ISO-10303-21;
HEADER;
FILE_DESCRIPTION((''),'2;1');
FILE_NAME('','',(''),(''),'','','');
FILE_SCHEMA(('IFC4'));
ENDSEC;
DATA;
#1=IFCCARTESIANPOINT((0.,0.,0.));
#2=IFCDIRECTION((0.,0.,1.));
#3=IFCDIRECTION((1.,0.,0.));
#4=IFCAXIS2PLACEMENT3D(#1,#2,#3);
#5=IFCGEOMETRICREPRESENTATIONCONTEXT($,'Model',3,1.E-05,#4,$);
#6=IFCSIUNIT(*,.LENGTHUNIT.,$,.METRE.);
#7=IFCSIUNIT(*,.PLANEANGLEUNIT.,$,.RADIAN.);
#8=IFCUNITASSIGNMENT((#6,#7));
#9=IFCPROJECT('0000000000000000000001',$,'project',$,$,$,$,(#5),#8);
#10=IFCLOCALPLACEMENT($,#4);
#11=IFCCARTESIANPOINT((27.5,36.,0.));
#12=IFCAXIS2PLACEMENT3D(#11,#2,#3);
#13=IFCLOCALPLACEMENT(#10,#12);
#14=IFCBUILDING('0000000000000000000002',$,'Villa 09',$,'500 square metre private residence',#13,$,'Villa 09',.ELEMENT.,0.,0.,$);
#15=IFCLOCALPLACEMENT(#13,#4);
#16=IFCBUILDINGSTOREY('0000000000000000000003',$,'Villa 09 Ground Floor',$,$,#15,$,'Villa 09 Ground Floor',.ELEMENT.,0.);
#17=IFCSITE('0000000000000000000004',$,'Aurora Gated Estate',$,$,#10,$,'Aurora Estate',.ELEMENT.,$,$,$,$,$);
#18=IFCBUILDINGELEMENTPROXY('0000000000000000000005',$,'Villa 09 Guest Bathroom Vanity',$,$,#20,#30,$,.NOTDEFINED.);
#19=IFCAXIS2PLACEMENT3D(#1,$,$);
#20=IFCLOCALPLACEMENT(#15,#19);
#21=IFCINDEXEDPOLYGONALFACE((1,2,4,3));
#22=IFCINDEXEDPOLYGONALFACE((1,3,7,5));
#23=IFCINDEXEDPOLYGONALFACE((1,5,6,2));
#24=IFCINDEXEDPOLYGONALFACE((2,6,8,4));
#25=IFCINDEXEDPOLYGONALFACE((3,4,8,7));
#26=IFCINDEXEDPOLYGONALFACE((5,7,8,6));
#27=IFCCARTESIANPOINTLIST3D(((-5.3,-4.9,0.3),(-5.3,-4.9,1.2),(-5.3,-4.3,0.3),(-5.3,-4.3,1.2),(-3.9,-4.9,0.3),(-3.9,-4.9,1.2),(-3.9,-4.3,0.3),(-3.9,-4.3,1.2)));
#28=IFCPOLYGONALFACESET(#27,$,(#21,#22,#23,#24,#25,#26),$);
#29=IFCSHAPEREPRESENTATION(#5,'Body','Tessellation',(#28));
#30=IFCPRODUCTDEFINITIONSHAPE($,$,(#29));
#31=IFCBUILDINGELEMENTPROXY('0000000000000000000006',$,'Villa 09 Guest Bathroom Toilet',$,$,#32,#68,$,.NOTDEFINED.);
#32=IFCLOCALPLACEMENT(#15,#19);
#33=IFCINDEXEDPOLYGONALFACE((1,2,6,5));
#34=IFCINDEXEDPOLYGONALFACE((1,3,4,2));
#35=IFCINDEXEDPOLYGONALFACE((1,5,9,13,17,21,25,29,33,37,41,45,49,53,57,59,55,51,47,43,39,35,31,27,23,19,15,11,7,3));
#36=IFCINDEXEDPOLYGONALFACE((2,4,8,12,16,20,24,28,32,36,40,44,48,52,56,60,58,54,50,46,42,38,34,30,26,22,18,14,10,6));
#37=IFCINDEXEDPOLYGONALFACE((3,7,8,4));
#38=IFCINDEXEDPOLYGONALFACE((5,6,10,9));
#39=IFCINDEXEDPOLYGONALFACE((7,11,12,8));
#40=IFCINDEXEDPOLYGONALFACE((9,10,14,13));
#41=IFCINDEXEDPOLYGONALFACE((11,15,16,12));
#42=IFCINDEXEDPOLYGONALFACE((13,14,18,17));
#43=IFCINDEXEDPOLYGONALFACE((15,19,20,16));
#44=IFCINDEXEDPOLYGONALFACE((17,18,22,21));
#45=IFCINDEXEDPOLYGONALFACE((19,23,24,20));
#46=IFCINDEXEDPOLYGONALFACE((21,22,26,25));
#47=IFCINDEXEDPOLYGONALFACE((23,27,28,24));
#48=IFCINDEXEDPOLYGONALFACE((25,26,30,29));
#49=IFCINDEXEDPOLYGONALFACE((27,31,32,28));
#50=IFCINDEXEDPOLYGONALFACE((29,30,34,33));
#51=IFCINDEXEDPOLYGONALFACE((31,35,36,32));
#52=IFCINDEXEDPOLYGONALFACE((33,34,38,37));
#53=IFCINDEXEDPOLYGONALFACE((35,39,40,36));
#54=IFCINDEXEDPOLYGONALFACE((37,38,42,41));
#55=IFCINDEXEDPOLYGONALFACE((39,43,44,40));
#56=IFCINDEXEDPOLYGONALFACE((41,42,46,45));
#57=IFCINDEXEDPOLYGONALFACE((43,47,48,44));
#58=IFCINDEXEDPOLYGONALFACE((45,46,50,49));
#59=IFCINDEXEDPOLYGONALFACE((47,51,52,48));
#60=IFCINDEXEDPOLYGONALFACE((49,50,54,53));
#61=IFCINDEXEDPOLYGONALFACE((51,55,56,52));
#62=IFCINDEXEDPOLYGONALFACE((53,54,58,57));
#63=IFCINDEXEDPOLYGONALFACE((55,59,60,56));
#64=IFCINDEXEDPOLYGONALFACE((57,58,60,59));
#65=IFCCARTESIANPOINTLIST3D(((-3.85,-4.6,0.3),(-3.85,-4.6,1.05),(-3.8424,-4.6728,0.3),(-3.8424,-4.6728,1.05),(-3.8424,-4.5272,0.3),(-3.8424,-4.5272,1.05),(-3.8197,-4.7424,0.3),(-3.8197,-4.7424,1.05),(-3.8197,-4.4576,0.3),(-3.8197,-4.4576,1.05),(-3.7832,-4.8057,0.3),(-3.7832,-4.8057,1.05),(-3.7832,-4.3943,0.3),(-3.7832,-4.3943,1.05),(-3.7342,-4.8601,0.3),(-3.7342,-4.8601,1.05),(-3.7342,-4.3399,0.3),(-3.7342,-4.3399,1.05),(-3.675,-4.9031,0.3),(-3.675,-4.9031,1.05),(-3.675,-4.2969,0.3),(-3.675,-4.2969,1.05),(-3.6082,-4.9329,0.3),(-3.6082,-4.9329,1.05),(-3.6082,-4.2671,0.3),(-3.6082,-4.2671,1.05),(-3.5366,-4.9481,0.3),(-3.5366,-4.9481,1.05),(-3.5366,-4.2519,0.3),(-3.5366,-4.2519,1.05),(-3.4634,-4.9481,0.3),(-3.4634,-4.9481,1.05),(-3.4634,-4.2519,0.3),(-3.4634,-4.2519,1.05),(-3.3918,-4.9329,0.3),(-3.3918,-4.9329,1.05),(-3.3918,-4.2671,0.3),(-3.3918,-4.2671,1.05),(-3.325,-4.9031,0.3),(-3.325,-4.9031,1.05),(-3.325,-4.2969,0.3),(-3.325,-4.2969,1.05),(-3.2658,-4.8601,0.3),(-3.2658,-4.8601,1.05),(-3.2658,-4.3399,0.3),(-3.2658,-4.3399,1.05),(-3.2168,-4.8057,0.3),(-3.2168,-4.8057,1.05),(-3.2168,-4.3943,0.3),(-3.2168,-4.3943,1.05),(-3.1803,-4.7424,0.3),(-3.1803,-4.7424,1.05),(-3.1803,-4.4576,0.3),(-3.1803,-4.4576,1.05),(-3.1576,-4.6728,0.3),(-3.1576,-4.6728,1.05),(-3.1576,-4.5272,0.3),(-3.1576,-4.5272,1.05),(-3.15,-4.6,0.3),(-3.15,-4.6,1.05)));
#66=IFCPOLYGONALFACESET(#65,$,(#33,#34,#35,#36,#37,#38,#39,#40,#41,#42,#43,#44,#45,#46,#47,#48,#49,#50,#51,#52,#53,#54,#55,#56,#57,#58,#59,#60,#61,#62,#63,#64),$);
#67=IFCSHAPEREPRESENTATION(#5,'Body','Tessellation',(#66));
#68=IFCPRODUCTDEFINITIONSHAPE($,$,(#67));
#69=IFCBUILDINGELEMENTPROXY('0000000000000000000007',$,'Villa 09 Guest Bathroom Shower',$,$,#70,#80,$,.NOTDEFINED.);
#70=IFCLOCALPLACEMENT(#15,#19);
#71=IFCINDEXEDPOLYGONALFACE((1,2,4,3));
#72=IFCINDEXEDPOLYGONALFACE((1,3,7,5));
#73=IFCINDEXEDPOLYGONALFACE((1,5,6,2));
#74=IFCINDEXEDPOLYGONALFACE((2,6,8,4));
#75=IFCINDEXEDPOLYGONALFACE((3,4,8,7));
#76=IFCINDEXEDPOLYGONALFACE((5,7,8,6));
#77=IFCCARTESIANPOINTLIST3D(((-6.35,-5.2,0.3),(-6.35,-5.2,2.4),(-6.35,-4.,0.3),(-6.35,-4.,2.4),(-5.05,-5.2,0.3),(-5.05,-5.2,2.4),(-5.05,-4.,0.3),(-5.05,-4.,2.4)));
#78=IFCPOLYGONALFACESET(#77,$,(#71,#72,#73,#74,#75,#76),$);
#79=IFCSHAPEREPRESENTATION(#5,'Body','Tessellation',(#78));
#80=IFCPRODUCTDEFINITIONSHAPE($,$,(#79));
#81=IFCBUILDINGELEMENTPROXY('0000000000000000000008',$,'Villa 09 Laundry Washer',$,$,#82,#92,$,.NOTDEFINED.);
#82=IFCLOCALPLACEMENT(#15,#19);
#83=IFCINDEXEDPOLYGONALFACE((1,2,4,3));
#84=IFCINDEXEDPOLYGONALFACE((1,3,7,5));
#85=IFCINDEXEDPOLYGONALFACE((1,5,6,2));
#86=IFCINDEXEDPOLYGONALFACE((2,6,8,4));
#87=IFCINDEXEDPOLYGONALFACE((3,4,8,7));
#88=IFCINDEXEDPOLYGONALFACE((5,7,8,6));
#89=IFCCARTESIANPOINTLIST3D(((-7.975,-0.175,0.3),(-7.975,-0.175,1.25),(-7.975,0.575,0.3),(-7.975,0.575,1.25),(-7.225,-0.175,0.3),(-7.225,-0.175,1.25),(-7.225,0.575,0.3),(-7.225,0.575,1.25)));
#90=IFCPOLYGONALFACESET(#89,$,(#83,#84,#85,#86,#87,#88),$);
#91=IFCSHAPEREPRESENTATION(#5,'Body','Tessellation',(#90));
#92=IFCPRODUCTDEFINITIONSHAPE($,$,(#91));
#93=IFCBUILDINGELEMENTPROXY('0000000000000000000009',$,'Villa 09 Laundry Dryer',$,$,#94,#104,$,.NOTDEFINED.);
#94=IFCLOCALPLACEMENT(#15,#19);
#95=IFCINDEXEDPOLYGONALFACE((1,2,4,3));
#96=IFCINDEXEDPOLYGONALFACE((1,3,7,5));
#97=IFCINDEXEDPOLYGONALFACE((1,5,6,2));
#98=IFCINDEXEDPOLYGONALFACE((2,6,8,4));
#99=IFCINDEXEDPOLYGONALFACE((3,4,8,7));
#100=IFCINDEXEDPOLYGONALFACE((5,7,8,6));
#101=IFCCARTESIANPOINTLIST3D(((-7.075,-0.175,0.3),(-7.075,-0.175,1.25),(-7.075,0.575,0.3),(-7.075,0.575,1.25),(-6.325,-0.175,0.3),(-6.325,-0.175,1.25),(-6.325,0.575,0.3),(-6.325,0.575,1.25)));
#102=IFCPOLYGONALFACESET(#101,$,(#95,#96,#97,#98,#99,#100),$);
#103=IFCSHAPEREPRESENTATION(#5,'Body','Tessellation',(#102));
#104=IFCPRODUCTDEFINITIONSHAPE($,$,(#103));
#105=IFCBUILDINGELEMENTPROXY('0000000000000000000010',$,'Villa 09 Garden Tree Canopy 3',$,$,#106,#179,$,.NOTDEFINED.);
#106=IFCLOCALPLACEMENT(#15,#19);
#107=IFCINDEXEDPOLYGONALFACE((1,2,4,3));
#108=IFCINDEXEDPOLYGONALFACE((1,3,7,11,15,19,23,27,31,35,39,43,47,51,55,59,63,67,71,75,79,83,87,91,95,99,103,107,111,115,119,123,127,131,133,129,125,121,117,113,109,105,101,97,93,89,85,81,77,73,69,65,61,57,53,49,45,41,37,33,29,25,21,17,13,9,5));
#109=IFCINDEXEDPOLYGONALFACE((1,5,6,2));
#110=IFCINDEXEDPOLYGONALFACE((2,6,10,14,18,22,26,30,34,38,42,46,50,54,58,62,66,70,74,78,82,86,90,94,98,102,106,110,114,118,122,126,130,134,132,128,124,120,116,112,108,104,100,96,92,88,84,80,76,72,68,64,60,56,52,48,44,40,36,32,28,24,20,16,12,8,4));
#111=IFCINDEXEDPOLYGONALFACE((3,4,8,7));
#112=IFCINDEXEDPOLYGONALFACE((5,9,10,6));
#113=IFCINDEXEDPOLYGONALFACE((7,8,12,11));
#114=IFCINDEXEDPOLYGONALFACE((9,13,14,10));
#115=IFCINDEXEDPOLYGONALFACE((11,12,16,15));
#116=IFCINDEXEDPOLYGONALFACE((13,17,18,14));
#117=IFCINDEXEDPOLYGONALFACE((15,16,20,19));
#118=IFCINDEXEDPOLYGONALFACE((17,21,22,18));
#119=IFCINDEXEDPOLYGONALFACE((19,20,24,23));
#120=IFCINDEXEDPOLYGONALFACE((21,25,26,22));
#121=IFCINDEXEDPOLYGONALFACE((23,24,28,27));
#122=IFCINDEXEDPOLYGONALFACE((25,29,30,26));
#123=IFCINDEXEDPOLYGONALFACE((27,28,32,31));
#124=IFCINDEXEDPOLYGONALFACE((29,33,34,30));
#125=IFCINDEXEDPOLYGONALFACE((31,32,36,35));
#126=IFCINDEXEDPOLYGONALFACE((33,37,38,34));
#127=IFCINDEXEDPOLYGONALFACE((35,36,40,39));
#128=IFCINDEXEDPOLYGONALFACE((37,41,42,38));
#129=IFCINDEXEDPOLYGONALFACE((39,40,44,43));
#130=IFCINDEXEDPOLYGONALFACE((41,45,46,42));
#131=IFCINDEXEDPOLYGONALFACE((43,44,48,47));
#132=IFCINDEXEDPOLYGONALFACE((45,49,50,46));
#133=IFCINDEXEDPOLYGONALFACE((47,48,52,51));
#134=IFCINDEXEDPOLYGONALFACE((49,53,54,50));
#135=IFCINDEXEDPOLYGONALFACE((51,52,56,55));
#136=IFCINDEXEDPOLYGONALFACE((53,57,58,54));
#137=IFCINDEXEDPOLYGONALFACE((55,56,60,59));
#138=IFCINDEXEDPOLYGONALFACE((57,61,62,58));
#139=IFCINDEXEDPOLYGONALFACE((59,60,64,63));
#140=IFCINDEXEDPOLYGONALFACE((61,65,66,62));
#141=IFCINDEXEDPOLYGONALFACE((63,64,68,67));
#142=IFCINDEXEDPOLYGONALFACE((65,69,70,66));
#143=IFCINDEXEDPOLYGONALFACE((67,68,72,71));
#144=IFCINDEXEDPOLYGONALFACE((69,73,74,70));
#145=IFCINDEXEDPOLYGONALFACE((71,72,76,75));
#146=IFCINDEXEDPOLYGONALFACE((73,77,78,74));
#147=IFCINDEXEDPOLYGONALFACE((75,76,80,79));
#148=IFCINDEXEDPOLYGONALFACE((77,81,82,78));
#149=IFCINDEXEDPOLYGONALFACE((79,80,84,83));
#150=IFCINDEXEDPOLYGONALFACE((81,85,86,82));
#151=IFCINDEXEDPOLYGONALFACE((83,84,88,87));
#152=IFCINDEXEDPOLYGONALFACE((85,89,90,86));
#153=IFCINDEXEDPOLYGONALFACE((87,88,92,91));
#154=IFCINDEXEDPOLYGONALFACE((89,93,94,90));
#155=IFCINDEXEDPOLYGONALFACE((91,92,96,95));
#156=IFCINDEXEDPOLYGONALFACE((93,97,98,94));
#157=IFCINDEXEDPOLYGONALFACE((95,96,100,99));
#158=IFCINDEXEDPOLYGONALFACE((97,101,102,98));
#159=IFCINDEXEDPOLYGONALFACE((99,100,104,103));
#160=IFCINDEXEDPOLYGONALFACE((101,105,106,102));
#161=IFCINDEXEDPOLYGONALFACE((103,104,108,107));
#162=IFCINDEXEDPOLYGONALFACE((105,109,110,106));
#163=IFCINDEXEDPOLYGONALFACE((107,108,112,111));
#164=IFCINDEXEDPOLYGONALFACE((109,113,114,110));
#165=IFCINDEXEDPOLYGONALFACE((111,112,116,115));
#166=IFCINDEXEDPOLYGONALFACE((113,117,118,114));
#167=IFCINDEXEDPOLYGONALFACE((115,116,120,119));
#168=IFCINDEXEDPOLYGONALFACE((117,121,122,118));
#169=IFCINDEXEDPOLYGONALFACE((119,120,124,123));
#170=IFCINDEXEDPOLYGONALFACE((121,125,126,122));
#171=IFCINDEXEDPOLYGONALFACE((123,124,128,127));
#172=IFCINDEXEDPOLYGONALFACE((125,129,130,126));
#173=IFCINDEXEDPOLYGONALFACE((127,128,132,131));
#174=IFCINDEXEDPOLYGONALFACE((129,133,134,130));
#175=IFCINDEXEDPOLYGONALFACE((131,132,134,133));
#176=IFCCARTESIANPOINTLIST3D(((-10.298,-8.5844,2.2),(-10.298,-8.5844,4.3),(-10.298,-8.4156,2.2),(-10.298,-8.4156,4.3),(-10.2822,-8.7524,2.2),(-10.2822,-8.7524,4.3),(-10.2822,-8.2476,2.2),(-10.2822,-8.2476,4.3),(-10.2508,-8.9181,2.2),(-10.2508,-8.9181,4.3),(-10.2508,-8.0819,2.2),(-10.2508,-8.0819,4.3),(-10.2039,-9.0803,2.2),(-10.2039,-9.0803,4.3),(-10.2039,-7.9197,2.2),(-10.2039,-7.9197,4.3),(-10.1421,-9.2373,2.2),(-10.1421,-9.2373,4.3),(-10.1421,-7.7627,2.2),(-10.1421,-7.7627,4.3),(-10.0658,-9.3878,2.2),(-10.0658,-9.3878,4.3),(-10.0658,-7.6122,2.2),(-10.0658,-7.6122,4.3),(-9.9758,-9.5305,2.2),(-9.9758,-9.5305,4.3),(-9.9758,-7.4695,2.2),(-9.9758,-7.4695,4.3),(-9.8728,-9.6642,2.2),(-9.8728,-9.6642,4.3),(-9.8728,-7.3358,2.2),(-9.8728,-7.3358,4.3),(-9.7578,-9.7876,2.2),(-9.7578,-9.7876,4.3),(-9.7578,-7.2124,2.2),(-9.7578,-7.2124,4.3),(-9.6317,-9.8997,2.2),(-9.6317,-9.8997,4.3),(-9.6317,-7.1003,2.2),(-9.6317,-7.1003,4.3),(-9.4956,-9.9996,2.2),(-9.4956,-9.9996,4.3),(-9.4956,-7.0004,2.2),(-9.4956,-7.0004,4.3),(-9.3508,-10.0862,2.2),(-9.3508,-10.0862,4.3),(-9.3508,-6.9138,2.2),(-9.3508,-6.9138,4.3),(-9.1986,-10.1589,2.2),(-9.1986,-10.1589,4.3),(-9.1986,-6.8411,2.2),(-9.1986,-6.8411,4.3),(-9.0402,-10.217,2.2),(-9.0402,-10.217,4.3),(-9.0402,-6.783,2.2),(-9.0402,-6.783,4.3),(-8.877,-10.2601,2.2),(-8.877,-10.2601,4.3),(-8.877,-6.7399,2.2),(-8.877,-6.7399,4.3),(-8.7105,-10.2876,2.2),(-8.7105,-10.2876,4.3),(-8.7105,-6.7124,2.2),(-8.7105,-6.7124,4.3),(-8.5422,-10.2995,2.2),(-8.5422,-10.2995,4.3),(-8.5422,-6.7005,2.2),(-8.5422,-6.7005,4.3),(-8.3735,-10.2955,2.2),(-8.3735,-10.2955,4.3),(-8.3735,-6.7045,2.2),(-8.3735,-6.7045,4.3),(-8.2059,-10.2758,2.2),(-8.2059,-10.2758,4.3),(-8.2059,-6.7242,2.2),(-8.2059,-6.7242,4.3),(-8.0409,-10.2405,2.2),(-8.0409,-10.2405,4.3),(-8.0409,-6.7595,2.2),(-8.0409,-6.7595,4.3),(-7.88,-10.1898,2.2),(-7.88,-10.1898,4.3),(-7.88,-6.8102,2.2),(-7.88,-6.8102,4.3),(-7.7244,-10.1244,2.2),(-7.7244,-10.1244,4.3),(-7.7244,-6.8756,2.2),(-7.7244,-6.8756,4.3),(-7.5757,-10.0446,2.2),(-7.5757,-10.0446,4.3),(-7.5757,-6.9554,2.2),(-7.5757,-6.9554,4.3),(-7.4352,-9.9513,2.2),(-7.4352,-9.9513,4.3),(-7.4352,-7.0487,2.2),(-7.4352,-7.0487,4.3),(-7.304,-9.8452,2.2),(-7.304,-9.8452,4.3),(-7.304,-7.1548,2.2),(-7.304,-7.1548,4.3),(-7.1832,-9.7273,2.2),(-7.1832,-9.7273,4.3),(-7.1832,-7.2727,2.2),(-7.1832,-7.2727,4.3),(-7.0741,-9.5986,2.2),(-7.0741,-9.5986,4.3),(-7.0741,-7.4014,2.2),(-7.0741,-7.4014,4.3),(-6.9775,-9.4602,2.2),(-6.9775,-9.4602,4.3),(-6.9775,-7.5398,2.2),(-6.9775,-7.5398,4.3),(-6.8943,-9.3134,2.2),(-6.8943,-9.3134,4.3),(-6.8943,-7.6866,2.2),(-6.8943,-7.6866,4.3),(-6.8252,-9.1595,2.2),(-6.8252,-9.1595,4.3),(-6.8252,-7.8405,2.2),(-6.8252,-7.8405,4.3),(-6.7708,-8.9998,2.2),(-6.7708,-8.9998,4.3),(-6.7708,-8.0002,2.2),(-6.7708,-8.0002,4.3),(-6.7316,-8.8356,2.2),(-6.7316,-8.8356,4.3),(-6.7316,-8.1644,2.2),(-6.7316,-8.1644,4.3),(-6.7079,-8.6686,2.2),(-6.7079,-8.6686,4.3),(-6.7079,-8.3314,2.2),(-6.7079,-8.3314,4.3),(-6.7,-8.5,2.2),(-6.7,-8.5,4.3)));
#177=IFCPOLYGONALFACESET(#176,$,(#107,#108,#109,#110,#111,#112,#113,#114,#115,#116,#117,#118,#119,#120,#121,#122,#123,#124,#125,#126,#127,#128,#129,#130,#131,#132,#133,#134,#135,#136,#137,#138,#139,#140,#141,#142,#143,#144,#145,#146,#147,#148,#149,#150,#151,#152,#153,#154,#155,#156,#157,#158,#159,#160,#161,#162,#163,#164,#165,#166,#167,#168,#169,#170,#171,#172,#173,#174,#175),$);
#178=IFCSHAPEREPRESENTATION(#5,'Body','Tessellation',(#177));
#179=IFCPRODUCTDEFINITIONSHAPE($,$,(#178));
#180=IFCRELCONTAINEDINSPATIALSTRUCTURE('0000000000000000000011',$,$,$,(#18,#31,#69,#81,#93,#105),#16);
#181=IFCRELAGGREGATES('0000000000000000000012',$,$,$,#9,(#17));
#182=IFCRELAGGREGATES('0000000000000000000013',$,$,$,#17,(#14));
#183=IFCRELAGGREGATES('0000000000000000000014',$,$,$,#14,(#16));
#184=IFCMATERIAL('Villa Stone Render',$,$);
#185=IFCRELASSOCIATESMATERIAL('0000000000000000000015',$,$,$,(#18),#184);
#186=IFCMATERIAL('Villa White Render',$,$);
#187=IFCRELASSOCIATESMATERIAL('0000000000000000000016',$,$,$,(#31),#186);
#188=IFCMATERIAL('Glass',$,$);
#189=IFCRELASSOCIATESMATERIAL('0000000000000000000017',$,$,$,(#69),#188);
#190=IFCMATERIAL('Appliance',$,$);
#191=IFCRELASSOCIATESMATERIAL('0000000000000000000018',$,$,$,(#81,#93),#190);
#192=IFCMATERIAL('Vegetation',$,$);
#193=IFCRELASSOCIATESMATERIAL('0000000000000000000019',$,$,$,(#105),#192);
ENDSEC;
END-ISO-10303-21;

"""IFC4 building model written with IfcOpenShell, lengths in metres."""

from ifc_helpers import new_model, si_unit, frame, origin_with_axes, origin_2d_with_axis, place, context, project, spatial, rectangle, circle, extrude, material, element, save


model = new_model("IFC4")

# Units and contexts
model_context = context("Model", 3, precision=1e-05, world=origin_with_axes())
ifc_project = project(units=[si_unit("LENGTHUNIT", "METRE"), si_unit("PLANEANGLEUNIT", "RADIAN")], contexts=[model_context])

# Site, building, storey
site_placement = place(None, origin_with_axes())
site = spatial("IfcSite", under=ifc_project, at=site_placement, Name="Aurora Gated Estate", LongName="Aurora Estate", CompositionType="ELEMENT")
building_placement = place(site_placement, frame((27.5, 36.0, 0.0), z_axis=(0.0, 0.0, 1.0), x_axis=(1.0, 0.0, 0.0)))
building = spatial("IfcBuilding", under=site, at=building_placement, Name="Villa 09", ObjectType="500 square metre private residence", LongName="Villa 09", CompositionType="ELEMENT", ElevationOfRefHeight=0.0, ElevationOfTerrain=0.0)
storey_placement = place(building_placement, origin_with_axes())
storey = spatial("IfcBuildingStorey", under=building, at=storey_placement, Name="Villa 09 Ground Floor", LongName="Villa 09 Ground Floor", CompositionType="ELEMENT", Elevation=0.0)

# Shared definitions
ifc_material_1 = material(Name="Villa Stone Render")

# Building element proxies
ifc_material_2 = material(Name="Glass")
proxy_1_placement = place(storey_placement, frame((-4.6, -4.6, 0.3), z_axis=(0.0, 0.0, 1.0), x_axis=(1.0, 0.0, 0.0)))
element("IfcBuildingElementProxy", 1, at=proxy_1_placement, inside=storey, material=ifc_material_1, Name="Villa 09 Guest Bathroom Vanity", PredefinedType="NOTDEFINED", context=model_context, shape_type="SweptSolid", body=[
    extrude(rectangle(XDim=1.4, YDim=0.6, at=origin_2d_with_axis()), origin_with_axes(), (0.0, 0.0, 1.0), 0.9),
])
ifc_material_3 = material(Name="Villa White Render")
proxy_2_placement = place(storey_placement, frame((-3.5, -4.6, 0.3), z_axis=(0.0, 0.0, 1.0), x_axis=(1.0, 0.0, 0.0)))
element("IfcBuildingElementProxy", 2, at=proxy_2_placement, inside=storey, material=ifc_material_3, Name="Villa 09 Guest Bathroom Toilet", PredefinedType="NOTDEFINED", context=model_context, shape_type="SweptSolid", body=[
    extrude(circle(Radius=0.35, at=origin_2d_with_axis()), origin_with_axes(), (0.0, 0.0, 1.0), 0.75),
])
proxy_3_placement = place(storey_placement, frame((-5.7, -4.6, 0.3), z_axis=(0.0, 0.0, 1.0), x_axis=(1.0, 0.0, 0.0)))
element("IfcBuildingElementProxy", 3, at=proxy_3_placement, inside=storey, material=ifc_material_2, Name="Villa 09 Guest Bathroom Shower", PredefinedType="NOTDEFINED", context=model_context, shape_type="SweptSolid", body=[
    extrude(rectangle(XDim=1.3, YDim=1.2, at=origin_2d_with_axis()), origin_with_axes(), (0.0, 0.0, 1.0), 2.1),
])
ifc_material_4 = material(Name="Appliance")
for number, where, z_axis, x_axis, name in (
    (4, (-7.6, 0.2, 0.3), (0.0, 0.0, 1.0), (1.0, 0.0, 0.0), "Villa 09 Laundry Washer"),
    (5, (-6.7, 0.2, 0.3), (0.0, 0.0, 1.0), (1.0, 0.0, 0.0), "Villa 09 Laundry Dryer"),
):
    element("IfcBuildingElementProxy", number, at=place(storey_placement, frame(where, z_axis=z_axis, x_axis=x_axis)), inside=storey, material=ifc_material_4, Name=name, PredefinedType="NOTDEFINED", context=model_context, shape_type="SweptSolid", body=[
        extrude(rectangle(XDim=0.75, YDim=0.75, at=origin_2d_with_axis()), origin_with_axes(), (0.0, 0.0, 1.0), 0.95),
    ])
ifc_material_5 = material(Name="Vegetation")
proxy_4_placement = place(storey_placement, frame((-8.5, -8.5, 2.2), z_axis=(0.0, 0.0, 1.0), x_axis=(1.0, 0.0, 0.0)))
element("IfcBuildingElementProxy", 6, at=proxy_4_placement, inside=storey, material=ifc_material_5, Name="Villa 09 Garden Tree Canopy 3", PredefinedType="NOTDEFINED", context=model_context, shape_type="SweptSolid", body=[
    extrude(circle(Radius=1.8, at=origin_2d_with_axis()), origin_with_axes(), (0.0, 0.0, 1.0), 2.1),
])

save(model, "model.ifc")
